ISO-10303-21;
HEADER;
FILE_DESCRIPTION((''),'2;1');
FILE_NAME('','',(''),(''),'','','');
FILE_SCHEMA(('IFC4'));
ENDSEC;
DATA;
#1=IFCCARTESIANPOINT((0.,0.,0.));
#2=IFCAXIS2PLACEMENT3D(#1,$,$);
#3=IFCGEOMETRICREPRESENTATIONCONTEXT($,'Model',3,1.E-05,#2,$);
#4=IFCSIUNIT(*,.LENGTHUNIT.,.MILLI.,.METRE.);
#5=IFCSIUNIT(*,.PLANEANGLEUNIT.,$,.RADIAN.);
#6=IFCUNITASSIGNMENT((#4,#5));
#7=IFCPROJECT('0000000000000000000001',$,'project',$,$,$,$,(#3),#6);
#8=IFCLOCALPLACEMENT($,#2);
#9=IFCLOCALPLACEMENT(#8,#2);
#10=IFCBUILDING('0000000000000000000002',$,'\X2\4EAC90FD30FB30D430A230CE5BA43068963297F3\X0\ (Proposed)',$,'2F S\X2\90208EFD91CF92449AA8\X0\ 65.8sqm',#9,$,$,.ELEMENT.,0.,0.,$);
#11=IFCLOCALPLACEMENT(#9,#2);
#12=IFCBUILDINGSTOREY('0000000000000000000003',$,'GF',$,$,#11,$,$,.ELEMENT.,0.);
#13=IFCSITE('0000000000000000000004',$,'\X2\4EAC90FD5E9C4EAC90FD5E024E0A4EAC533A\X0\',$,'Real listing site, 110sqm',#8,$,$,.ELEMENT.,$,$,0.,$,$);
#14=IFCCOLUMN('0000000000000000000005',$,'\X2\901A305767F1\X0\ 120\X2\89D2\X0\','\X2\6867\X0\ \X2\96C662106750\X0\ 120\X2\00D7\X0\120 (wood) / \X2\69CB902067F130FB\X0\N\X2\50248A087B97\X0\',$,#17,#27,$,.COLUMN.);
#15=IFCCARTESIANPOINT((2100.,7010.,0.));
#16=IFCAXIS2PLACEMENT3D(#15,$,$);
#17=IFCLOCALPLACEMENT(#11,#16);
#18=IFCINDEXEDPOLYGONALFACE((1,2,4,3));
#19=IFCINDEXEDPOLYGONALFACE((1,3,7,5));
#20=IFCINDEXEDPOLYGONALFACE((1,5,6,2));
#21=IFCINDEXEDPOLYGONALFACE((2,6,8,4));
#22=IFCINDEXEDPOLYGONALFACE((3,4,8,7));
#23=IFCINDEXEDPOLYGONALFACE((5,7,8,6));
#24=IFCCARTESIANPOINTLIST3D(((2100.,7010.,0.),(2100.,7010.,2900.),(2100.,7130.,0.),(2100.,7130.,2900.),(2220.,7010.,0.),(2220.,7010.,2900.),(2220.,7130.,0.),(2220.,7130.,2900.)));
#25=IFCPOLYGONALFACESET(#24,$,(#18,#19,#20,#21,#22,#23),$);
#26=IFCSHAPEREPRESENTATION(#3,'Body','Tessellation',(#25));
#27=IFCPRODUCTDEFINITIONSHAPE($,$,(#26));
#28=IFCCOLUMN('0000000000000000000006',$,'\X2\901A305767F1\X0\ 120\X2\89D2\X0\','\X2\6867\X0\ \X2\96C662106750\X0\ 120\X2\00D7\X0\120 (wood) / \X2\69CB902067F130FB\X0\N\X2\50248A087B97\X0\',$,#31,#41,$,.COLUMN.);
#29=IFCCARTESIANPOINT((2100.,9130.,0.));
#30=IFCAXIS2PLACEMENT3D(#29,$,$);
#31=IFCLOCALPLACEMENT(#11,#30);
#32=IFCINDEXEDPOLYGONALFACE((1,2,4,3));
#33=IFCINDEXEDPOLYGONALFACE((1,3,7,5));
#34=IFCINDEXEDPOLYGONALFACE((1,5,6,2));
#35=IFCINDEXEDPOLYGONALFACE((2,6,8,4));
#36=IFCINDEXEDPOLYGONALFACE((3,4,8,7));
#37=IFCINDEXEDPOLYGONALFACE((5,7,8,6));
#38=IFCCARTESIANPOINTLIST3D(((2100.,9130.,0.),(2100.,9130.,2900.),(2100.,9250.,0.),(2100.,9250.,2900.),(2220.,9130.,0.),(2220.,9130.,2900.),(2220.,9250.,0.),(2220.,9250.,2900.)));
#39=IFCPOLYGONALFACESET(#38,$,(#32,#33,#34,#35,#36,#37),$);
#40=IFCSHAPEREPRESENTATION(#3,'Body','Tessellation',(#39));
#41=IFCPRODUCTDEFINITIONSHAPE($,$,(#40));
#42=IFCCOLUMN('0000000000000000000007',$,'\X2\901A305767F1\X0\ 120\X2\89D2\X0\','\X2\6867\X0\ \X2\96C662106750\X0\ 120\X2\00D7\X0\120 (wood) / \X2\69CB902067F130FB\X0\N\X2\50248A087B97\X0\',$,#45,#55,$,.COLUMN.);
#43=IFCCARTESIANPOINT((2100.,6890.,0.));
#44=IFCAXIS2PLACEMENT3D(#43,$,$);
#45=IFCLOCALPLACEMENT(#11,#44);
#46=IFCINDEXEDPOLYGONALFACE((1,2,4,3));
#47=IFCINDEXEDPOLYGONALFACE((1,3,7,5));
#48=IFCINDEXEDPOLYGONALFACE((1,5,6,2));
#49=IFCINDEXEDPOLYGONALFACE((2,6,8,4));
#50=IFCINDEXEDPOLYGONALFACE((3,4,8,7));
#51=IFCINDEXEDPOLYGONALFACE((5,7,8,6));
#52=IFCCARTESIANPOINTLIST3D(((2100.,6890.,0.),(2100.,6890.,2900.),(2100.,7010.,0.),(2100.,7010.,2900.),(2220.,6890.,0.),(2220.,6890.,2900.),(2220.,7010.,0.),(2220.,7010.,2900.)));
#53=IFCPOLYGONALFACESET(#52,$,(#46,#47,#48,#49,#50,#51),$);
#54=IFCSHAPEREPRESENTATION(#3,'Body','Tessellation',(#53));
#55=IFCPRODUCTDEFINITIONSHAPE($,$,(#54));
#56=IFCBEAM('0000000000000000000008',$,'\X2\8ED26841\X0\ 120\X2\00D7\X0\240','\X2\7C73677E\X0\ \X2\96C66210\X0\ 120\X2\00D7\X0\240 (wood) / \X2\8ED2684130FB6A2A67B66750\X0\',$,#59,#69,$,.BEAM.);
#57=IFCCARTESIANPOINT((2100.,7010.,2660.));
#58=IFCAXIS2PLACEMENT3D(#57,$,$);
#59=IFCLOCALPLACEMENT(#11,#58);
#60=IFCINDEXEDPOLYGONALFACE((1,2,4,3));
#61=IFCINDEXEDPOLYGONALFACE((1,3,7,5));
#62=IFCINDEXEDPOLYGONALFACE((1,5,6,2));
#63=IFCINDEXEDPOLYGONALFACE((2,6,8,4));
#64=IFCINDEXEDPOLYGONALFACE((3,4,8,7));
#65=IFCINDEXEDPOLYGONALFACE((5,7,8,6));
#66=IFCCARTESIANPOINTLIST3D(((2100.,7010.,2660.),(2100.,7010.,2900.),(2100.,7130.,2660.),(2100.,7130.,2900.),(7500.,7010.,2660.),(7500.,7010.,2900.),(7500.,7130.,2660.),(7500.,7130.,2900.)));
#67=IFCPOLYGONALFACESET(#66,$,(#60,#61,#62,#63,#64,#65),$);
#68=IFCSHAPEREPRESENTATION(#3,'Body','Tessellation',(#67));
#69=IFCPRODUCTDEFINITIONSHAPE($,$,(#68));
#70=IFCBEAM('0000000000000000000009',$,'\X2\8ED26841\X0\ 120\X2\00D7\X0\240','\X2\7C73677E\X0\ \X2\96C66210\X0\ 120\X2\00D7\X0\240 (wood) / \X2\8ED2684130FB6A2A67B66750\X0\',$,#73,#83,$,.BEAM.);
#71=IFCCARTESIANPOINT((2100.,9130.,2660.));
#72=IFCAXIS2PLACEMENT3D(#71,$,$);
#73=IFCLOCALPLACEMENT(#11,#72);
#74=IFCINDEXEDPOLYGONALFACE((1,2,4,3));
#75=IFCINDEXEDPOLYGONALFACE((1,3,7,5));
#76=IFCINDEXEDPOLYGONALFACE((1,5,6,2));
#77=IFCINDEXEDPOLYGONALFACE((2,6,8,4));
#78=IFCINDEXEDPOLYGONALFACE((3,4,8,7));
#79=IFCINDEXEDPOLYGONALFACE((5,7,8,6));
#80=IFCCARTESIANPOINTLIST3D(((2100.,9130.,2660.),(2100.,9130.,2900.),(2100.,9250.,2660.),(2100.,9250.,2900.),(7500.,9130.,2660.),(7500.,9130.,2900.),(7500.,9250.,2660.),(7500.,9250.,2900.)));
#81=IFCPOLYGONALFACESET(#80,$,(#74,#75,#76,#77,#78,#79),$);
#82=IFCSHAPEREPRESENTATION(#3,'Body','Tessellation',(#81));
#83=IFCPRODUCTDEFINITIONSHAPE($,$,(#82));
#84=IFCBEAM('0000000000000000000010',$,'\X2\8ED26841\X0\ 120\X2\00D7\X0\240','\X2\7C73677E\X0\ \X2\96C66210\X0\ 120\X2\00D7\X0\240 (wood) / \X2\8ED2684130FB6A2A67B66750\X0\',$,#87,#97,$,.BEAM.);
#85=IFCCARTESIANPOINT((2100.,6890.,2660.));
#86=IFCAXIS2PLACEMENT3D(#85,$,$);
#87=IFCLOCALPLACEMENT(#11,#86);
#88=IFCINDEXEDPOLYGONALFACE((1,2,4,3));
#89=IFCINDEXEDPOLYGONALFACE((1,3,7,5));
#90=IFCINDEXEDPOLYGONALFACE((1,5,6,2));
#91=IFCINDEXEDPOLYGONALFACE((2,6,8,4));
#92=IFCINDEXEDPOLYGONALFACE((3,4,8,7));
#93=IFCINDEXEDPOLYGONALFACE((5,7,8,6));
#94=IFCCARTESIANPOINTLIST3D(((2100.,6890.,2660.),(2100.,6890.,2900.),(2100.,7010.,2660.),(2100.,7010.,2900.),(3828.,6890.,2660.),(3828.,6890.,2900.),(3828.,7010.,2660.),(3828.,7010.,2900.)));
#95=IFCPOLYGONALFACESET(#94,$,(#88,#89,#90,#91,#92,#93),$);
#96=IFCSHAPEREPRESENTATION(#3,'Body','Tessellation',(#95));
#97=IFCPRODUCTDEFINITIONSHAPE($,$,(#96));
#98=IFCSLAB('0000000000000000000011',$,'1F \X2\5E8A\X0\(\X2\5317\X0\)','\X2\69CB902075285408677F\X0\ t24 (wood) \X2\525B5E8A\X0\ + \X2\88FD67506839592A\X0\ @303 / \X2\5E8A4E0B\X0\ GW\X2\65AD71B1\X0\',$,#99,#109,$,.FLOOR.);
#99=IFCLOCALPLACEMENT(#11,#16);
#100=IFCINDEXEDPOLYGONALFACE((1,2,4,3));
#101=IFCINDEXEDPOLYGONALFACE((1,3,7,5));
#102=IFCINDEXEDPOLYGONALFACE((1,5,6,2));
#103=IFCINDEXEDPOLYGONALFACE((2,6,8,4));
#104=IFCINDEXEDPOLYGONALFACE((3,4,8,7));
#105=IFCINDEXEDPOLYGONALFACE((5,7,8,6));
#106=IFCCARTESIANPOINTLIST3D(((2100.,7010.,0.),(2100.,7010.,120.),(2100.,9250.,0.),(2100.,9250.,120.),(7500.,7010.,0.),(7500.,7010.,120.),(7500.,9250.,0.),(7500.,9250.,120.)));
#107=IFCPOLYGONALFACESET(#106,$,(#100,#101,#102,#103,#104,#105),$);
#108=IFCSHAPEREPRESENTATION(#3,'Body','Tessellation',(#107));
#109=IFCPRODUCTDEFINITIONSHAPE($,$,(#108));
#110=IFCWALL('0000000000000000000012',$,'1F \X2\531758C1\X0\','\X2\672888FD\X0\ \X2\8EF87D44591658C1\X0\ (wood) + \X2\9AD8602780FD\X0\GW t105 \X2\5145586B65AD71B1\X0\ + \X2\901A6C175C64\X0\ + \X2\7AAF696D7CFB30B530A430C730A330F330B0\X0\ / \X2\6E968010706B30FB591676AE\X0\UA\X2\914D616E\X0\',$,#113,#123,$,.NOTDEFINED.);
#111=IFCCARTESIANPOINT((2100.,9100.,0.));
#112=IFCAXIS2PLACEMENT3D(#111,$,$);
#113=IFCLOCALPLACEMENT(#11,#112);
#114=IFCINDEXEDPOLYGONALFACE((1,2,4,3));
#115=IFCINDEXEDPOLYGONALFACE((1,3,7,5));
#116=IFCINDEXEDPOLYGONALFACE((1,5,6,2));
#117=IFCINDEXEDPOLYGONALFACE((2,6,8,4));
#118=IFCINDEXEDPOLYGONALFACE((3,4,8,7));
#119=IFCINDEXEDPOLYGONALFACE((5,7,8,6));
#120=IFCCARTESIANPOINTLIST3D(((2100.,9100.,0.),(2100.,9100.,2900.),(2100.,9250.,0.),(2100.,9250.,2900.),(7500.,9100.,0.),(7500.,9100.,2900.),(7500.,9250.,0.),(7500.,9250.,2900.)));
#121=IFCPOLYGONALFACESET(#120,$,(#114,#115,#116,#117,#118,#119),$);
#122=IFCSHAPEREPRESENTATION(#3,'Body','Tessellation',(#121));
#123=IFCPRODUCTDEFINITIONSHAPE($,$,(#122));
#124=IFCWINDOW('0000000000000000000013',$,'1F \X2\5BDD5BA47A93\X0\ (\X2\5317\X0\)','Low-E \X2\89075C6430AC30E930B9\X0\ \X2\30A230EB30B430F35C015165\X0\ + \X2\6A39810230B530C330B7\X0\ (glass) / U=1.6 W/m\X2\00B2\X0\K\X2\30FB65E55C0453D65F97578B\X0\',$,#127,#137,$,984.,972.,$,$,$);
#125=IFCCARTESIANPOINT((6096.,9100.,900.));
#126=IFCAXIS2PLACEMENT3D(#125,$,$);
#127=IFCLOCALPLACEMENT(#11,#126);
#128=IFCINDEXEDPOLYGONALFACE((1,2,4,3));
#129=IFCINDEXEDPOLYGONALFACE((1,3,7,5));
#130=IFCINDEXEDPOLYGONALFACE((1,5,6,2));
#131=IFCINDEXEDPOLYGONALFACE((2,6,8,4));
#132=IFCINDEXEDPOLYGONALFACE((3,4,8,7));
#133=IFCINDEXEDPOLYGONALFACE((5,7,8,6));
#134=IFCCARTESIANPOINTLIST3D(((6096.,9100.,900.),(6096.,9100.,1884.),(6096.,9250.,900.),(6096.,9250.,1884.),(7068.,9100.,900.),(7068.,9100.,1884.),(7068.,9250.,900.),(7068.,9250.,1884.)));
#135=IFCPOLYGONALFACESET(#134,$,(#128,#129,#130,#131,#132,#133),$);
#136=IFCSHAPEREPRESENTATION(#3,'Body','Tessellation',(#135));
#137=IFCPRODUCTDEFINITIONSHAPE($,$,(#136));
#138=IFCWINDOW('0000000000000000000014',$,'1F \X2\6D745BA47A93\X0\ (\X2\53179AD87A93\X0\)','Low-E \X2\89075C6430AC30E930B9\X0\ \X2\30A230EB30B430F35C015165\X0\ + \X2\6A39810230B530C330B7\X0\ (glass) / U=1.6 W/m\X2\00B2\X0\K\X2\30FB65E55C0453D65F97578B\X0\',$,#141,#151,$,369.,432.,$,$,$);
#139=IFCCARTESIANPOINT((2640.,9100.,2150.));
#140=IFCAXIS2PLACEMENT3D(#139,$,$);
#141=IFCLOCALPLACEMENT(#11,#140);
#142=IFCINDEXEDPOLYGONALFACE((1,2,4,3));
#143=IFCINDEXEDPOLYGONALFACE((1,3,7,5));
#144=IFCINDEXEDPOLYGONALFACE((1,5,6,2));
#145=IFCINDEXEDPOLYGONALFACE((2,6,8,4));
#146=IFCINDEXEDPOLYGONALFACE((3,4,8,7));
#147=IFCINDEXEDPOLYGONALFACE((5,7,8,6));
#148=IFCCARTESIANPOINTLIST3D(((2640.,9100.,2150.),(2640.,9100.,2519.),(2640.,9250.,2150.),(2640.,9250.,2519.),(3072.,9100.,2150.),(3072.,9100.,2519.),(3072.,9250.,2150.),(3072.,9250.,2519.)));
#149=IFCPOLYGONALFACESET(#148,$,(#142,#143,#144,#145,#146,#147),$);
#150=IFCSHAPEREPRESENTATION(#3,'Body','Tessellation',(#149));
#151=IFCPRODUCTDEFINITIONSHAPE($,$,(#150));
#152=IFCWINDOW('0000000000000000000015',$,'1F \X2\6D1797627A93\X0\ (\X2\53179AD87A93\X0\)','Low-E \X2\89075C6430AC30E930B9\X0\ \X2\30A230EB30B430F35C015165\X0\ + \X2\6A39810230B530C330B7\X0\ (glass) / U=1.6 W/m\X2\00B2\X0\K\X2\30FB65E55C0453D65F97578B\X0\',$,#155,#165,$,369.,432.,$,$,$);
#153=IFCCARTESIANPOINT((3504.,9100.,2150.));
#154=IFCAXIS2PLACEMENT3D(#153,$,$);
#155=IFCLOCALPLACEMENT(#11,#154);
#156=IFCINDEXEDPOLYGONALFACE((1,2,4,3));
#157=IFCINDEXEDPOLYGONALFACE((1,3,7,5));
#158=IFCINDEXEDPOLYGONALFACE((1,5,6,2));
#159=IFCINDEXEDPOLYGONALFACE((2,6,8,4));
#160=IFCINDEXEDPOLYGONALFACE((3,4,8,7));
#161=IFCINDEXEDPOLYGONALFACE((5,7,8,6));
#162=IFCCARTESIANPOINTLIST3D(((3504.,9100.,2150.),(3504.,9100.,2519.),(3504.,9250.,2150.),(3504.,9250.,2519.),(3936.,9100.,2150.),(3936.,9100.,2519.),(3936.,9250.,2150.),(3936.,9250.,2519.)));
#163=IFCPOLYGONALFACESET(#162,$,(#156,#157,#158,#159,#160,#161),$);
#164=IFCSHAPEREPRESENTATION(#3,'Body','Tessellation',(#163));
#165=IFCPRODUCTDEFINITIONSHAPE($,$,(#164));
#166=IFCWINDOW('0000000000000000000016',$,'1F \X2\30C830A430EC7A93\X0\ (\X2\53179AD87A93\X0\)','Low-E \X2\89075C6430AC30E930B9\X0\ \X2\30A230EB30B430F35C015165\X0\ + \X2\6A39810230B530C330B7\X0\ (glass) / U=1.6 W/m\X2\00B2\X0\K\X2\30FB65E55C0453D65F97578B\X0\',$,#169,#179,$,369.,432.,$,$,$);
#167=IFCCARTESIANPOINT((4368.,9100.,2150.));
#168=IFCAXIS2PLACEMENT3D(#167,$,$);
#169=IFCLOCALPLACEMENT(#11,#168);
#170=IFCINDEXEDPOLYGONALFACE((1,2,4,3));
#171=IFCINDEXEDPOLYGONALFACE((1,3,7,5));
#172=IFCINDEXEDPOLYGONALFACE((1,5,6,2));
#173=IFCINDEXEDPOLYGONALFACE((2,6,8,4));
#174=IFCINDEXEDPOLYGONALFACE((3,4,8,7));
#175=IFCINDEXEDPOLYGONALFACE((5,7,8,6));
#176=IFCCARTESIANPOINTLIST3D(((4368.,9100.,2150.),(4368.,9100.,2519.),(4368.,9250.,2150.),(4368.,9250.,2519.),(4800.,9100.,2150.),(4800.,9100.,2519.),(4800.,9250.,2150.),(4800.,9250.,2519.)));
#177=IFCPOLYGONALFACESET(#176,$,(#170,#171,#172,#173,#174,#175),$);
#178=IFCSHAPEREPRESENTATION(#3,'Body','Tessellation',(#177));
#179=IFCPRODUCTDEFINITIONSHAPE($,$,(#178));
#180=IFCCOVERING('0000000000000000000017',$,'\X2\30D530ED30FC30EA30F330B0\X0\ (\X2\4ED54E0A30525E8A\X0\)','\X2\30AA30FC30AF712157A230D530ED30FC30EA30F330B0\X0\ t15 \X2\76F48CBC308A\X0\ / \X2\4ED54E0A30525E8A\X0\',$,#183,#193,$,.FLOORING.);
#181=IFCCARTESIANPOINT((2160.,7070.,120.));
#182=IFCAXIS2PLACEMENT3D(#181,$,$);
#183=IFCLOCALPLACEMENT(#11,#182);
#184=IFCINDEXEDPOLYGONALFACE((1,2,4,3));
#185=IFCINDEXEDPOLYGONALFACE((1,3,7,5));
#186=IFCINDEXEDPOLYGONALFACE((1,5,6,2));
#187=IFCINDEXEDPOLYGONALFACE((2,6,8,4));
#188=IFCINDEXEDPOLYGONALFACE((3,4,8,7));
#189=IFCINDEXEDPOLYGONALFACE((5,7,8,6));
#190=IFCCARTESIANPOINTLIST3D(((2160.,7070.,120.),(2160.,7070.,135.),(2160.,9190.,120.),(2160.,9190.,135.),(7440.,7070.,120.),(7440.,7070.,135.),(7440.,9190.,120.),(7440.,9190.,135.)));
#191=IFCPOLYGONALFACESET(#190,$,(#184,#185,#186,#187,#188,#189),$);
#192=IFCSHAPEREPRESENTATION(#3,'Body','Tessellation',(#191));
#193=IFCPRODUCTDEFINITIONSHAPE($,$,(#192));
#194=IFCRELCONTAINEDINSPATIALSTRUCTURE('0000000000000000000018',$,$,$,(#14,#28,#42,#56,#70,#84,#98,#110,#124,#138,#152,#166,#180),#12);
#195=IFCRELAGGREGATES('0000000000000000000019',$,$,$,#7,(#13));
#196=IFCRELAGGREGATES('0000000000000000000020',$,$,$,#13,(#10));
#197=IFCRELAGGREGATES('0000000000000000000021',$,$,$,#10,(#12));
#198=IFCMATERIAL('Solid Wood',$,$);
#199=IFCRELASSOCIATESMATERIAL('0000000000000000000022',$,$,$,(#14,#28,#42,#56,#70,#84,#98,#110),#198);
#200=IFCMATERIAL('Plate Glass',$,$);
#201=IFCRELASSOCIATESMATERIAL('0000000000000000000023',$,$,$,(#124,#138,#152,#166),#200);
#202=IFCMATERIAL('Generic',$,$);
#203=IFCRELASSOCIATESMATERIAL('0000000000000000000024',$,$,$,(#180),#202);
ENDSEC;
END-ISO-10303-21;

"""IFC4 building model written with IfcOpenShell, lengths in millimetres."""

from ifc_helpers import new_model, si_unit, frame, frame_2d, origin, place, context, project, spatial, rectangle, extrude, material, element, fill, save


model = new_model("IFC4")

# Units and contexts
model_context = context("Model", 3, precision=1e-05, world=origin())
ifc_project = project(units=[si_unit("LENGTHUNIT", "METRE", prefix="MILLI"), si_unit("PLANEANGLEUNIT", "RADIAN")], contexts=[model_context])

# Site, building, storey
site_placement = place(None, origin())
site = spatial("IfcSite", under=ifc_project, at=site_placement, Name="京都府京都市上京区", ObjectType="Real listing site, 110sqm", CompositionType="ELEMENT", RefElevation=0.0)
building_placement = place(site_placement, origin())
building = spatial("IfcBuilding", under=site, at=building_placement, Name="京都・ピアノ室と防音 (Proposed)", ObjectType="2F S造軽量鉄骨 65.8sqm", CompositionType="ELEMENT", ElevationOfRefHeight=0.0, ElevationOfTerrain=0.0)
storey_placement = place(building_placement, origin())
storey = spatial("IfcBuildingStorey", under=building, at=storey_placement, Name="GF", CompositionType="ELEMENT", Elevation=0.0)

# Columns
ifc_material_1 = material(Name="Solid Wood")
column_1_placement = place(storey_placement, frame((2100.0, 7010.0, 0.0)))
element("IfcColumn", 1, at=column_1_placement, inside=storey, material=ifc_material_1, Name="通し柱 120角", Description="桧 集成材 120×120 (wood) / 構造柱・N値計算", PredefinedType="COLUMN", context=model_context, shape_type="SweptSolid", body=[
    extrude(rectangle(XDim=120.0, YDim=120.0, at=frame_2d((60.0, 60.0))), frame((2100.0, 7010.0, 0.0)), (0.0, 0.0, 1.0), 2900.0),
])
column_2_placement = place(storey_placement, frame((2100.0, 9130.0, 0.0)))
element("IfcColumn", 2, at=column_2_placement, inside=storey, material=ifc_material_1, Name="通し柱 120角", Description="桧 集成材 120×120 (wood) / 構造柱・N値計算", PredefinedType="COLUMN", context=model_context, shape_type="SweptSolid", body=[
    extrude(rectangle(XDim=120.0, YDim=120.0, at=frame_2d((60.0, 60.0))), frame((2100.0, 9130.0, 0.0)), (0.0, 0.0, 1.0), 2900.0),
])
column_3_placement = place(storey_placement, frame((2100.0, 6890.0, 0.0)))
element("IfcColumn", 3, at=column_3_placement, inside=storey, material=ifc_material_1, Name="通し柱 120角", Description="桧 集成材 120×120 (wood) / 構造柱・N値計算", PredefinedType="COLUMN", context=model_context, shape_type="SweptSolid", body=[
    extrude(rectangle(XDim=120.0, YDim=120.0, at=frame_2d((60.0, 60.0))), frame((2100.0, 6890.0, 0.0)), (0.0, 0.0, 1.0), 2900.0),
])

# Beams
beam_1_placement = place(storey_placement, frame((2100.0, 7010.0, 2660.0)))
element("IfcBeam", 4, at=beam_1_placement, inside=storey, material=ifc_material_1, Name="軒桁 120×240", Description="米松 集成 120×240 (wood) / 軒桁・横架材", PredefinedType="BEAM", context=model_context, shape_type="SweptSolid", body=[
    extrude(rectangle(XDim=5400.0, YDim=120.0, at=frame_2d((2700.0, 60.0))), frame((2100.0, 7010.0, 2660.0)), (0.0, 0.0, 1.0), 240.0),
])
beam_2_placement = place(storey_placement, frame((2100.0, 9130.0, 2660.0)))
element("IfcBeam", 5, at=beam_2_placement, inside=storey, material=ifc_material_1, Name="軒桁 120×240", Description="米松 集成 120×240 (wood) / 軒桁・横架材", PredefinedType="BEAM", context=model_context, shape_type="SweptSolid", body=[
    extrude(rectangle(XDim=5400.0, YDim=120.0, at=frame_2d((2700.0, 60.0))), frame((2100.0, 9130.0, 2660.0)), (0.0, 0.0, 1.0), 240.0),
])
beam_3_placement = place(storey_placement, frame((2100.0, 6890.0, 2660.0)))
element("IfcBeam", 6, at=beam_3_placement, inside=storey, material=ifc_material_1, Name="軒桁 120×240", Description="米松 集成 120×240 (wood) / 軒桁・横架材", PredefinedType="BEAM", context=model_context, shape_type="SweptSolid", body=[
    extrude(rectangle(XDim=1728.0, YDim=120.0, at=frame_2d((864.0, 60.0))), frame((2100.0, 6890.0, 2660.0)), (0.0, 0.0, 1.0), 240.0),
])

# Slab
slab_placement = place(storey_placement, frame((2100.0, 7010.0, 0.0)))
element("IfcSlab", 7, at=slab_placement, inside=storey, material=ifc_material_1, Name="1F 床(北)", Description="構造用合板 t24 (wood) 剛床 + 製材根太 @303 / 床下 GW断熱", PredefinedType="FLOOR", context=model_context, shape_type="SweptSolid", body=[
    extrude(rectangle(XDim=5400.0, YDim=2240.0, at=frame_2d((2700.0, 1120.0))), frame((2100.0, 7010.0, 0.0)), (0.0, 0.0, 1.0), 120.0),
])

# Wall, openings, windows
wall_1_placement = place(storey_placement, frame((2100.0, 9100.0, 0.0)))
wall_1 = element("IfcWall", 8, at=wall_1_placement, inside=storey, material=ifc_material_1, Name="1F 北壁", Description="木製 軸組外壁 (wood) + 高性能GW t105 充填断熱 + 通気層 + 窯業系サイディング / 準耐火・外皮UA配慮", PredefinedType="NOTDEFINED", context=model_context, shape_type="SweptSolid", body=[
    extrude(rectangle(XDim=5400.0, YDim=150.0, at=frame_2d((2700.0, 75.0))), frame((2100.0, 9100.0, 0.0)), (0.0, 0.0, 1.0), 2900.0),
])
opening_1_placement = place(storey_placement, frame((6096.0, 9100.0, 900.0)))
opening_1 = element("IfcOpeningElement", 9, at=opening_1_placement, cuts=wall_1, PredefinedType="NOTDEFINED", context=model_context, shape_type="SweptSolid", body=[
    extrude(rectangle(XDim=972.0, YDim=150.0, at=frame_2d((486.0, 75.0))), frame((6096.0, 9100.0, 900.0)), (0.0, 0.0, 1.0), 984.0),
])
opening_2_placement = place(storey_placement, frame((2640.0, 9100.0, 2150.0)))
opening_2 = element("IfcOpeningElement", 10, at=opening_2_placement, cuts=wall_1, PredefinedType="NOTDEFINED", context=model_context, shape_type="SweptSolid", body=[
    extrude(rectangle(XDim=432.0, YDim=150.0, at=frame_2d((216.0, 75.0))), frame((2640.0, 9100.0, 2150.0)), (0.0, 0.0, 1.0), 369.0),
])
opening_3_placement = place(storey_placement, frame((3504.0, 9100.0, 2150.0)))
opening_3 = element("IfcOpeningElement", 11, at=opening_3_placement, cuts=wall_1, PredefinedType="NOTDEFINED", context=model_context, shape_type="SweptSolid", body=[
    extrude(rectangle(XDim=432.0, YDim=150.0, at=frame_2d((216.0, 75.0))), frame((3504.0, 9100.0, 2150.0)), (0.0, 0.0, 1.0), 369.0),
])
opening_4_placement = place(storey_placement, frame((4368.0, 9100.0, 2150.0)))
opening_4 = element("IfcOpeningElement", 12, at=opening_4_placement, cuts=wall_1, PredefinedType="NOTDEFINED", context=model_context, shape_type="SweptSolid", body=[
    extrude(rectangle(XDim=432.0, YDim=150.0, at=frame_2d((216.0, 75.0))), frame((4368.0, 9100.0, 2150.0)), (0.0, 0.0, 1.0), 369.0),
])
ifc_material_2 = material(Name="Plate Glass")
window_1_placement = place(storey_placement, frame((6096.0, 9100.0, 900.0)))
window_1 = element("IfcWindow", 13, at=window_1_placement, inside=storey, material=ifc_material_2, Name="1F 寝室窓 (北)", Description="Low-E 複層ガラス アルゴン封入 + 樹脂サッシ (glass) / U=1.6 W/m²K・日射取得型", OverallHeight=984.0, OverallWidth=972.0, context=model_context, shape_type="SweptSolid", body=[
    extrude(rectangle(XDim=972.0, YDim=150.0, at=frame_2d((486.0, 75.0))), frame((6096.0, 9100.0, 900.0)), (0.0, 0.0, 1.0), 984.0),
])
fill(opening_1, window_1)
window_2_placement = place(storey_placement, frame((2640.0, 9100.0, 2150.0)))
window_2 = element("IfcWindow", 14, at=window_2_placement, inside=storey, material=ifc_material_2, Name="1F 浴室窓 (北高窓)", Description="Low-E 複層ガラス アルゴン封入 + 樹脂サッシ (glass) / U=1.6 W/m²K・日射取得型", OverallHeight=369.0, OverallWidth=432.0, context=model_context, shape_type="SweptSolid", body=[
    extrude(rectangle(XDim=432.0, YDim=150.0, at=frame_2d((216.0, 75.0))), frame((2640.0, 9100.0, 2150.0)), (0.0, 0.0, 1.0), 369.0),
])
fill(opening_2, window_2)
window_3_placement = place(storey_placement, frame((3504.0, 9100.0, 2150.0)))
window_3 = element("IfcWindow", 15, at=window_3_placement, inside=storey, material=ifc_material_2, Name="1F 洗面窓 (北高窓)", Description="Low-E 複層ガラス アルゴン封入 + 樹脂サッシ (glass) / U=1.6 W/m²K・日射取得型", OverallHeight=369.0, OverallWidth=432.0, context=model_context, shape_type="SweptSolid", body=[
    extrude(rectangle(XDim=432.0, YDim=150.0, at=frame_2d((216.0, 75.0))), frame((3504.0, 9100.0, 2150.0)), (0.0, 0.0, 1.0), 369.0),
])
fill(opening_3, window_3)
window_4_placement = place(storey_placement, frame((4368.0, 9100.0, 2150.0)))
window_4 = element("IfcWindow", 16, at=window_4_placement, inside=storey, material=ifc_material_2, Name="1F トイレ窓 (北高窓)", Description="Low-E 複層ガラス アルゴン封入 + 樹脂サッシ (glass) / U=1.6 W/m²K・日射取得型", OverallHeight=369.0, OverallWidth=432.0, context=model_context, shape_type="SweptSolid", body=[
    extrude(rectangle(XDim=432.0, YDim=150.0, at=frame_2d((216.0, 75.0))), frame((4368.0, 9100.0, 2150.0)), (0.0, 0.0, 1.0), 369.0),
])
fill(opening_4, window_4)

# Covering
ifc_material_3 = material(Name="Generic")
covering_1_placement = place(storey_placement, frame((2160.0, 7070.0, 120.0)))
element("IfcCovering", 17, at=covering_1_placement, inside=storey, material=ifc_material_3, Name="フローリング (仕上げ床)", Description="オーク無垢フローリング t15 直貼り / 仕上げ床", PredefinedType="FLOORING", context=model_context, shape_type="SweptSolid", body=[
    extrude(rectangle(XDim=5280.0, YDim=2120.0, at=frame_2d((2640.0, 1060.0))), frame((2160.0, 7070.0, 120.0)), (0.0, 0.0, 1.0), 15.0),
])

save(model, "model.ifc")
